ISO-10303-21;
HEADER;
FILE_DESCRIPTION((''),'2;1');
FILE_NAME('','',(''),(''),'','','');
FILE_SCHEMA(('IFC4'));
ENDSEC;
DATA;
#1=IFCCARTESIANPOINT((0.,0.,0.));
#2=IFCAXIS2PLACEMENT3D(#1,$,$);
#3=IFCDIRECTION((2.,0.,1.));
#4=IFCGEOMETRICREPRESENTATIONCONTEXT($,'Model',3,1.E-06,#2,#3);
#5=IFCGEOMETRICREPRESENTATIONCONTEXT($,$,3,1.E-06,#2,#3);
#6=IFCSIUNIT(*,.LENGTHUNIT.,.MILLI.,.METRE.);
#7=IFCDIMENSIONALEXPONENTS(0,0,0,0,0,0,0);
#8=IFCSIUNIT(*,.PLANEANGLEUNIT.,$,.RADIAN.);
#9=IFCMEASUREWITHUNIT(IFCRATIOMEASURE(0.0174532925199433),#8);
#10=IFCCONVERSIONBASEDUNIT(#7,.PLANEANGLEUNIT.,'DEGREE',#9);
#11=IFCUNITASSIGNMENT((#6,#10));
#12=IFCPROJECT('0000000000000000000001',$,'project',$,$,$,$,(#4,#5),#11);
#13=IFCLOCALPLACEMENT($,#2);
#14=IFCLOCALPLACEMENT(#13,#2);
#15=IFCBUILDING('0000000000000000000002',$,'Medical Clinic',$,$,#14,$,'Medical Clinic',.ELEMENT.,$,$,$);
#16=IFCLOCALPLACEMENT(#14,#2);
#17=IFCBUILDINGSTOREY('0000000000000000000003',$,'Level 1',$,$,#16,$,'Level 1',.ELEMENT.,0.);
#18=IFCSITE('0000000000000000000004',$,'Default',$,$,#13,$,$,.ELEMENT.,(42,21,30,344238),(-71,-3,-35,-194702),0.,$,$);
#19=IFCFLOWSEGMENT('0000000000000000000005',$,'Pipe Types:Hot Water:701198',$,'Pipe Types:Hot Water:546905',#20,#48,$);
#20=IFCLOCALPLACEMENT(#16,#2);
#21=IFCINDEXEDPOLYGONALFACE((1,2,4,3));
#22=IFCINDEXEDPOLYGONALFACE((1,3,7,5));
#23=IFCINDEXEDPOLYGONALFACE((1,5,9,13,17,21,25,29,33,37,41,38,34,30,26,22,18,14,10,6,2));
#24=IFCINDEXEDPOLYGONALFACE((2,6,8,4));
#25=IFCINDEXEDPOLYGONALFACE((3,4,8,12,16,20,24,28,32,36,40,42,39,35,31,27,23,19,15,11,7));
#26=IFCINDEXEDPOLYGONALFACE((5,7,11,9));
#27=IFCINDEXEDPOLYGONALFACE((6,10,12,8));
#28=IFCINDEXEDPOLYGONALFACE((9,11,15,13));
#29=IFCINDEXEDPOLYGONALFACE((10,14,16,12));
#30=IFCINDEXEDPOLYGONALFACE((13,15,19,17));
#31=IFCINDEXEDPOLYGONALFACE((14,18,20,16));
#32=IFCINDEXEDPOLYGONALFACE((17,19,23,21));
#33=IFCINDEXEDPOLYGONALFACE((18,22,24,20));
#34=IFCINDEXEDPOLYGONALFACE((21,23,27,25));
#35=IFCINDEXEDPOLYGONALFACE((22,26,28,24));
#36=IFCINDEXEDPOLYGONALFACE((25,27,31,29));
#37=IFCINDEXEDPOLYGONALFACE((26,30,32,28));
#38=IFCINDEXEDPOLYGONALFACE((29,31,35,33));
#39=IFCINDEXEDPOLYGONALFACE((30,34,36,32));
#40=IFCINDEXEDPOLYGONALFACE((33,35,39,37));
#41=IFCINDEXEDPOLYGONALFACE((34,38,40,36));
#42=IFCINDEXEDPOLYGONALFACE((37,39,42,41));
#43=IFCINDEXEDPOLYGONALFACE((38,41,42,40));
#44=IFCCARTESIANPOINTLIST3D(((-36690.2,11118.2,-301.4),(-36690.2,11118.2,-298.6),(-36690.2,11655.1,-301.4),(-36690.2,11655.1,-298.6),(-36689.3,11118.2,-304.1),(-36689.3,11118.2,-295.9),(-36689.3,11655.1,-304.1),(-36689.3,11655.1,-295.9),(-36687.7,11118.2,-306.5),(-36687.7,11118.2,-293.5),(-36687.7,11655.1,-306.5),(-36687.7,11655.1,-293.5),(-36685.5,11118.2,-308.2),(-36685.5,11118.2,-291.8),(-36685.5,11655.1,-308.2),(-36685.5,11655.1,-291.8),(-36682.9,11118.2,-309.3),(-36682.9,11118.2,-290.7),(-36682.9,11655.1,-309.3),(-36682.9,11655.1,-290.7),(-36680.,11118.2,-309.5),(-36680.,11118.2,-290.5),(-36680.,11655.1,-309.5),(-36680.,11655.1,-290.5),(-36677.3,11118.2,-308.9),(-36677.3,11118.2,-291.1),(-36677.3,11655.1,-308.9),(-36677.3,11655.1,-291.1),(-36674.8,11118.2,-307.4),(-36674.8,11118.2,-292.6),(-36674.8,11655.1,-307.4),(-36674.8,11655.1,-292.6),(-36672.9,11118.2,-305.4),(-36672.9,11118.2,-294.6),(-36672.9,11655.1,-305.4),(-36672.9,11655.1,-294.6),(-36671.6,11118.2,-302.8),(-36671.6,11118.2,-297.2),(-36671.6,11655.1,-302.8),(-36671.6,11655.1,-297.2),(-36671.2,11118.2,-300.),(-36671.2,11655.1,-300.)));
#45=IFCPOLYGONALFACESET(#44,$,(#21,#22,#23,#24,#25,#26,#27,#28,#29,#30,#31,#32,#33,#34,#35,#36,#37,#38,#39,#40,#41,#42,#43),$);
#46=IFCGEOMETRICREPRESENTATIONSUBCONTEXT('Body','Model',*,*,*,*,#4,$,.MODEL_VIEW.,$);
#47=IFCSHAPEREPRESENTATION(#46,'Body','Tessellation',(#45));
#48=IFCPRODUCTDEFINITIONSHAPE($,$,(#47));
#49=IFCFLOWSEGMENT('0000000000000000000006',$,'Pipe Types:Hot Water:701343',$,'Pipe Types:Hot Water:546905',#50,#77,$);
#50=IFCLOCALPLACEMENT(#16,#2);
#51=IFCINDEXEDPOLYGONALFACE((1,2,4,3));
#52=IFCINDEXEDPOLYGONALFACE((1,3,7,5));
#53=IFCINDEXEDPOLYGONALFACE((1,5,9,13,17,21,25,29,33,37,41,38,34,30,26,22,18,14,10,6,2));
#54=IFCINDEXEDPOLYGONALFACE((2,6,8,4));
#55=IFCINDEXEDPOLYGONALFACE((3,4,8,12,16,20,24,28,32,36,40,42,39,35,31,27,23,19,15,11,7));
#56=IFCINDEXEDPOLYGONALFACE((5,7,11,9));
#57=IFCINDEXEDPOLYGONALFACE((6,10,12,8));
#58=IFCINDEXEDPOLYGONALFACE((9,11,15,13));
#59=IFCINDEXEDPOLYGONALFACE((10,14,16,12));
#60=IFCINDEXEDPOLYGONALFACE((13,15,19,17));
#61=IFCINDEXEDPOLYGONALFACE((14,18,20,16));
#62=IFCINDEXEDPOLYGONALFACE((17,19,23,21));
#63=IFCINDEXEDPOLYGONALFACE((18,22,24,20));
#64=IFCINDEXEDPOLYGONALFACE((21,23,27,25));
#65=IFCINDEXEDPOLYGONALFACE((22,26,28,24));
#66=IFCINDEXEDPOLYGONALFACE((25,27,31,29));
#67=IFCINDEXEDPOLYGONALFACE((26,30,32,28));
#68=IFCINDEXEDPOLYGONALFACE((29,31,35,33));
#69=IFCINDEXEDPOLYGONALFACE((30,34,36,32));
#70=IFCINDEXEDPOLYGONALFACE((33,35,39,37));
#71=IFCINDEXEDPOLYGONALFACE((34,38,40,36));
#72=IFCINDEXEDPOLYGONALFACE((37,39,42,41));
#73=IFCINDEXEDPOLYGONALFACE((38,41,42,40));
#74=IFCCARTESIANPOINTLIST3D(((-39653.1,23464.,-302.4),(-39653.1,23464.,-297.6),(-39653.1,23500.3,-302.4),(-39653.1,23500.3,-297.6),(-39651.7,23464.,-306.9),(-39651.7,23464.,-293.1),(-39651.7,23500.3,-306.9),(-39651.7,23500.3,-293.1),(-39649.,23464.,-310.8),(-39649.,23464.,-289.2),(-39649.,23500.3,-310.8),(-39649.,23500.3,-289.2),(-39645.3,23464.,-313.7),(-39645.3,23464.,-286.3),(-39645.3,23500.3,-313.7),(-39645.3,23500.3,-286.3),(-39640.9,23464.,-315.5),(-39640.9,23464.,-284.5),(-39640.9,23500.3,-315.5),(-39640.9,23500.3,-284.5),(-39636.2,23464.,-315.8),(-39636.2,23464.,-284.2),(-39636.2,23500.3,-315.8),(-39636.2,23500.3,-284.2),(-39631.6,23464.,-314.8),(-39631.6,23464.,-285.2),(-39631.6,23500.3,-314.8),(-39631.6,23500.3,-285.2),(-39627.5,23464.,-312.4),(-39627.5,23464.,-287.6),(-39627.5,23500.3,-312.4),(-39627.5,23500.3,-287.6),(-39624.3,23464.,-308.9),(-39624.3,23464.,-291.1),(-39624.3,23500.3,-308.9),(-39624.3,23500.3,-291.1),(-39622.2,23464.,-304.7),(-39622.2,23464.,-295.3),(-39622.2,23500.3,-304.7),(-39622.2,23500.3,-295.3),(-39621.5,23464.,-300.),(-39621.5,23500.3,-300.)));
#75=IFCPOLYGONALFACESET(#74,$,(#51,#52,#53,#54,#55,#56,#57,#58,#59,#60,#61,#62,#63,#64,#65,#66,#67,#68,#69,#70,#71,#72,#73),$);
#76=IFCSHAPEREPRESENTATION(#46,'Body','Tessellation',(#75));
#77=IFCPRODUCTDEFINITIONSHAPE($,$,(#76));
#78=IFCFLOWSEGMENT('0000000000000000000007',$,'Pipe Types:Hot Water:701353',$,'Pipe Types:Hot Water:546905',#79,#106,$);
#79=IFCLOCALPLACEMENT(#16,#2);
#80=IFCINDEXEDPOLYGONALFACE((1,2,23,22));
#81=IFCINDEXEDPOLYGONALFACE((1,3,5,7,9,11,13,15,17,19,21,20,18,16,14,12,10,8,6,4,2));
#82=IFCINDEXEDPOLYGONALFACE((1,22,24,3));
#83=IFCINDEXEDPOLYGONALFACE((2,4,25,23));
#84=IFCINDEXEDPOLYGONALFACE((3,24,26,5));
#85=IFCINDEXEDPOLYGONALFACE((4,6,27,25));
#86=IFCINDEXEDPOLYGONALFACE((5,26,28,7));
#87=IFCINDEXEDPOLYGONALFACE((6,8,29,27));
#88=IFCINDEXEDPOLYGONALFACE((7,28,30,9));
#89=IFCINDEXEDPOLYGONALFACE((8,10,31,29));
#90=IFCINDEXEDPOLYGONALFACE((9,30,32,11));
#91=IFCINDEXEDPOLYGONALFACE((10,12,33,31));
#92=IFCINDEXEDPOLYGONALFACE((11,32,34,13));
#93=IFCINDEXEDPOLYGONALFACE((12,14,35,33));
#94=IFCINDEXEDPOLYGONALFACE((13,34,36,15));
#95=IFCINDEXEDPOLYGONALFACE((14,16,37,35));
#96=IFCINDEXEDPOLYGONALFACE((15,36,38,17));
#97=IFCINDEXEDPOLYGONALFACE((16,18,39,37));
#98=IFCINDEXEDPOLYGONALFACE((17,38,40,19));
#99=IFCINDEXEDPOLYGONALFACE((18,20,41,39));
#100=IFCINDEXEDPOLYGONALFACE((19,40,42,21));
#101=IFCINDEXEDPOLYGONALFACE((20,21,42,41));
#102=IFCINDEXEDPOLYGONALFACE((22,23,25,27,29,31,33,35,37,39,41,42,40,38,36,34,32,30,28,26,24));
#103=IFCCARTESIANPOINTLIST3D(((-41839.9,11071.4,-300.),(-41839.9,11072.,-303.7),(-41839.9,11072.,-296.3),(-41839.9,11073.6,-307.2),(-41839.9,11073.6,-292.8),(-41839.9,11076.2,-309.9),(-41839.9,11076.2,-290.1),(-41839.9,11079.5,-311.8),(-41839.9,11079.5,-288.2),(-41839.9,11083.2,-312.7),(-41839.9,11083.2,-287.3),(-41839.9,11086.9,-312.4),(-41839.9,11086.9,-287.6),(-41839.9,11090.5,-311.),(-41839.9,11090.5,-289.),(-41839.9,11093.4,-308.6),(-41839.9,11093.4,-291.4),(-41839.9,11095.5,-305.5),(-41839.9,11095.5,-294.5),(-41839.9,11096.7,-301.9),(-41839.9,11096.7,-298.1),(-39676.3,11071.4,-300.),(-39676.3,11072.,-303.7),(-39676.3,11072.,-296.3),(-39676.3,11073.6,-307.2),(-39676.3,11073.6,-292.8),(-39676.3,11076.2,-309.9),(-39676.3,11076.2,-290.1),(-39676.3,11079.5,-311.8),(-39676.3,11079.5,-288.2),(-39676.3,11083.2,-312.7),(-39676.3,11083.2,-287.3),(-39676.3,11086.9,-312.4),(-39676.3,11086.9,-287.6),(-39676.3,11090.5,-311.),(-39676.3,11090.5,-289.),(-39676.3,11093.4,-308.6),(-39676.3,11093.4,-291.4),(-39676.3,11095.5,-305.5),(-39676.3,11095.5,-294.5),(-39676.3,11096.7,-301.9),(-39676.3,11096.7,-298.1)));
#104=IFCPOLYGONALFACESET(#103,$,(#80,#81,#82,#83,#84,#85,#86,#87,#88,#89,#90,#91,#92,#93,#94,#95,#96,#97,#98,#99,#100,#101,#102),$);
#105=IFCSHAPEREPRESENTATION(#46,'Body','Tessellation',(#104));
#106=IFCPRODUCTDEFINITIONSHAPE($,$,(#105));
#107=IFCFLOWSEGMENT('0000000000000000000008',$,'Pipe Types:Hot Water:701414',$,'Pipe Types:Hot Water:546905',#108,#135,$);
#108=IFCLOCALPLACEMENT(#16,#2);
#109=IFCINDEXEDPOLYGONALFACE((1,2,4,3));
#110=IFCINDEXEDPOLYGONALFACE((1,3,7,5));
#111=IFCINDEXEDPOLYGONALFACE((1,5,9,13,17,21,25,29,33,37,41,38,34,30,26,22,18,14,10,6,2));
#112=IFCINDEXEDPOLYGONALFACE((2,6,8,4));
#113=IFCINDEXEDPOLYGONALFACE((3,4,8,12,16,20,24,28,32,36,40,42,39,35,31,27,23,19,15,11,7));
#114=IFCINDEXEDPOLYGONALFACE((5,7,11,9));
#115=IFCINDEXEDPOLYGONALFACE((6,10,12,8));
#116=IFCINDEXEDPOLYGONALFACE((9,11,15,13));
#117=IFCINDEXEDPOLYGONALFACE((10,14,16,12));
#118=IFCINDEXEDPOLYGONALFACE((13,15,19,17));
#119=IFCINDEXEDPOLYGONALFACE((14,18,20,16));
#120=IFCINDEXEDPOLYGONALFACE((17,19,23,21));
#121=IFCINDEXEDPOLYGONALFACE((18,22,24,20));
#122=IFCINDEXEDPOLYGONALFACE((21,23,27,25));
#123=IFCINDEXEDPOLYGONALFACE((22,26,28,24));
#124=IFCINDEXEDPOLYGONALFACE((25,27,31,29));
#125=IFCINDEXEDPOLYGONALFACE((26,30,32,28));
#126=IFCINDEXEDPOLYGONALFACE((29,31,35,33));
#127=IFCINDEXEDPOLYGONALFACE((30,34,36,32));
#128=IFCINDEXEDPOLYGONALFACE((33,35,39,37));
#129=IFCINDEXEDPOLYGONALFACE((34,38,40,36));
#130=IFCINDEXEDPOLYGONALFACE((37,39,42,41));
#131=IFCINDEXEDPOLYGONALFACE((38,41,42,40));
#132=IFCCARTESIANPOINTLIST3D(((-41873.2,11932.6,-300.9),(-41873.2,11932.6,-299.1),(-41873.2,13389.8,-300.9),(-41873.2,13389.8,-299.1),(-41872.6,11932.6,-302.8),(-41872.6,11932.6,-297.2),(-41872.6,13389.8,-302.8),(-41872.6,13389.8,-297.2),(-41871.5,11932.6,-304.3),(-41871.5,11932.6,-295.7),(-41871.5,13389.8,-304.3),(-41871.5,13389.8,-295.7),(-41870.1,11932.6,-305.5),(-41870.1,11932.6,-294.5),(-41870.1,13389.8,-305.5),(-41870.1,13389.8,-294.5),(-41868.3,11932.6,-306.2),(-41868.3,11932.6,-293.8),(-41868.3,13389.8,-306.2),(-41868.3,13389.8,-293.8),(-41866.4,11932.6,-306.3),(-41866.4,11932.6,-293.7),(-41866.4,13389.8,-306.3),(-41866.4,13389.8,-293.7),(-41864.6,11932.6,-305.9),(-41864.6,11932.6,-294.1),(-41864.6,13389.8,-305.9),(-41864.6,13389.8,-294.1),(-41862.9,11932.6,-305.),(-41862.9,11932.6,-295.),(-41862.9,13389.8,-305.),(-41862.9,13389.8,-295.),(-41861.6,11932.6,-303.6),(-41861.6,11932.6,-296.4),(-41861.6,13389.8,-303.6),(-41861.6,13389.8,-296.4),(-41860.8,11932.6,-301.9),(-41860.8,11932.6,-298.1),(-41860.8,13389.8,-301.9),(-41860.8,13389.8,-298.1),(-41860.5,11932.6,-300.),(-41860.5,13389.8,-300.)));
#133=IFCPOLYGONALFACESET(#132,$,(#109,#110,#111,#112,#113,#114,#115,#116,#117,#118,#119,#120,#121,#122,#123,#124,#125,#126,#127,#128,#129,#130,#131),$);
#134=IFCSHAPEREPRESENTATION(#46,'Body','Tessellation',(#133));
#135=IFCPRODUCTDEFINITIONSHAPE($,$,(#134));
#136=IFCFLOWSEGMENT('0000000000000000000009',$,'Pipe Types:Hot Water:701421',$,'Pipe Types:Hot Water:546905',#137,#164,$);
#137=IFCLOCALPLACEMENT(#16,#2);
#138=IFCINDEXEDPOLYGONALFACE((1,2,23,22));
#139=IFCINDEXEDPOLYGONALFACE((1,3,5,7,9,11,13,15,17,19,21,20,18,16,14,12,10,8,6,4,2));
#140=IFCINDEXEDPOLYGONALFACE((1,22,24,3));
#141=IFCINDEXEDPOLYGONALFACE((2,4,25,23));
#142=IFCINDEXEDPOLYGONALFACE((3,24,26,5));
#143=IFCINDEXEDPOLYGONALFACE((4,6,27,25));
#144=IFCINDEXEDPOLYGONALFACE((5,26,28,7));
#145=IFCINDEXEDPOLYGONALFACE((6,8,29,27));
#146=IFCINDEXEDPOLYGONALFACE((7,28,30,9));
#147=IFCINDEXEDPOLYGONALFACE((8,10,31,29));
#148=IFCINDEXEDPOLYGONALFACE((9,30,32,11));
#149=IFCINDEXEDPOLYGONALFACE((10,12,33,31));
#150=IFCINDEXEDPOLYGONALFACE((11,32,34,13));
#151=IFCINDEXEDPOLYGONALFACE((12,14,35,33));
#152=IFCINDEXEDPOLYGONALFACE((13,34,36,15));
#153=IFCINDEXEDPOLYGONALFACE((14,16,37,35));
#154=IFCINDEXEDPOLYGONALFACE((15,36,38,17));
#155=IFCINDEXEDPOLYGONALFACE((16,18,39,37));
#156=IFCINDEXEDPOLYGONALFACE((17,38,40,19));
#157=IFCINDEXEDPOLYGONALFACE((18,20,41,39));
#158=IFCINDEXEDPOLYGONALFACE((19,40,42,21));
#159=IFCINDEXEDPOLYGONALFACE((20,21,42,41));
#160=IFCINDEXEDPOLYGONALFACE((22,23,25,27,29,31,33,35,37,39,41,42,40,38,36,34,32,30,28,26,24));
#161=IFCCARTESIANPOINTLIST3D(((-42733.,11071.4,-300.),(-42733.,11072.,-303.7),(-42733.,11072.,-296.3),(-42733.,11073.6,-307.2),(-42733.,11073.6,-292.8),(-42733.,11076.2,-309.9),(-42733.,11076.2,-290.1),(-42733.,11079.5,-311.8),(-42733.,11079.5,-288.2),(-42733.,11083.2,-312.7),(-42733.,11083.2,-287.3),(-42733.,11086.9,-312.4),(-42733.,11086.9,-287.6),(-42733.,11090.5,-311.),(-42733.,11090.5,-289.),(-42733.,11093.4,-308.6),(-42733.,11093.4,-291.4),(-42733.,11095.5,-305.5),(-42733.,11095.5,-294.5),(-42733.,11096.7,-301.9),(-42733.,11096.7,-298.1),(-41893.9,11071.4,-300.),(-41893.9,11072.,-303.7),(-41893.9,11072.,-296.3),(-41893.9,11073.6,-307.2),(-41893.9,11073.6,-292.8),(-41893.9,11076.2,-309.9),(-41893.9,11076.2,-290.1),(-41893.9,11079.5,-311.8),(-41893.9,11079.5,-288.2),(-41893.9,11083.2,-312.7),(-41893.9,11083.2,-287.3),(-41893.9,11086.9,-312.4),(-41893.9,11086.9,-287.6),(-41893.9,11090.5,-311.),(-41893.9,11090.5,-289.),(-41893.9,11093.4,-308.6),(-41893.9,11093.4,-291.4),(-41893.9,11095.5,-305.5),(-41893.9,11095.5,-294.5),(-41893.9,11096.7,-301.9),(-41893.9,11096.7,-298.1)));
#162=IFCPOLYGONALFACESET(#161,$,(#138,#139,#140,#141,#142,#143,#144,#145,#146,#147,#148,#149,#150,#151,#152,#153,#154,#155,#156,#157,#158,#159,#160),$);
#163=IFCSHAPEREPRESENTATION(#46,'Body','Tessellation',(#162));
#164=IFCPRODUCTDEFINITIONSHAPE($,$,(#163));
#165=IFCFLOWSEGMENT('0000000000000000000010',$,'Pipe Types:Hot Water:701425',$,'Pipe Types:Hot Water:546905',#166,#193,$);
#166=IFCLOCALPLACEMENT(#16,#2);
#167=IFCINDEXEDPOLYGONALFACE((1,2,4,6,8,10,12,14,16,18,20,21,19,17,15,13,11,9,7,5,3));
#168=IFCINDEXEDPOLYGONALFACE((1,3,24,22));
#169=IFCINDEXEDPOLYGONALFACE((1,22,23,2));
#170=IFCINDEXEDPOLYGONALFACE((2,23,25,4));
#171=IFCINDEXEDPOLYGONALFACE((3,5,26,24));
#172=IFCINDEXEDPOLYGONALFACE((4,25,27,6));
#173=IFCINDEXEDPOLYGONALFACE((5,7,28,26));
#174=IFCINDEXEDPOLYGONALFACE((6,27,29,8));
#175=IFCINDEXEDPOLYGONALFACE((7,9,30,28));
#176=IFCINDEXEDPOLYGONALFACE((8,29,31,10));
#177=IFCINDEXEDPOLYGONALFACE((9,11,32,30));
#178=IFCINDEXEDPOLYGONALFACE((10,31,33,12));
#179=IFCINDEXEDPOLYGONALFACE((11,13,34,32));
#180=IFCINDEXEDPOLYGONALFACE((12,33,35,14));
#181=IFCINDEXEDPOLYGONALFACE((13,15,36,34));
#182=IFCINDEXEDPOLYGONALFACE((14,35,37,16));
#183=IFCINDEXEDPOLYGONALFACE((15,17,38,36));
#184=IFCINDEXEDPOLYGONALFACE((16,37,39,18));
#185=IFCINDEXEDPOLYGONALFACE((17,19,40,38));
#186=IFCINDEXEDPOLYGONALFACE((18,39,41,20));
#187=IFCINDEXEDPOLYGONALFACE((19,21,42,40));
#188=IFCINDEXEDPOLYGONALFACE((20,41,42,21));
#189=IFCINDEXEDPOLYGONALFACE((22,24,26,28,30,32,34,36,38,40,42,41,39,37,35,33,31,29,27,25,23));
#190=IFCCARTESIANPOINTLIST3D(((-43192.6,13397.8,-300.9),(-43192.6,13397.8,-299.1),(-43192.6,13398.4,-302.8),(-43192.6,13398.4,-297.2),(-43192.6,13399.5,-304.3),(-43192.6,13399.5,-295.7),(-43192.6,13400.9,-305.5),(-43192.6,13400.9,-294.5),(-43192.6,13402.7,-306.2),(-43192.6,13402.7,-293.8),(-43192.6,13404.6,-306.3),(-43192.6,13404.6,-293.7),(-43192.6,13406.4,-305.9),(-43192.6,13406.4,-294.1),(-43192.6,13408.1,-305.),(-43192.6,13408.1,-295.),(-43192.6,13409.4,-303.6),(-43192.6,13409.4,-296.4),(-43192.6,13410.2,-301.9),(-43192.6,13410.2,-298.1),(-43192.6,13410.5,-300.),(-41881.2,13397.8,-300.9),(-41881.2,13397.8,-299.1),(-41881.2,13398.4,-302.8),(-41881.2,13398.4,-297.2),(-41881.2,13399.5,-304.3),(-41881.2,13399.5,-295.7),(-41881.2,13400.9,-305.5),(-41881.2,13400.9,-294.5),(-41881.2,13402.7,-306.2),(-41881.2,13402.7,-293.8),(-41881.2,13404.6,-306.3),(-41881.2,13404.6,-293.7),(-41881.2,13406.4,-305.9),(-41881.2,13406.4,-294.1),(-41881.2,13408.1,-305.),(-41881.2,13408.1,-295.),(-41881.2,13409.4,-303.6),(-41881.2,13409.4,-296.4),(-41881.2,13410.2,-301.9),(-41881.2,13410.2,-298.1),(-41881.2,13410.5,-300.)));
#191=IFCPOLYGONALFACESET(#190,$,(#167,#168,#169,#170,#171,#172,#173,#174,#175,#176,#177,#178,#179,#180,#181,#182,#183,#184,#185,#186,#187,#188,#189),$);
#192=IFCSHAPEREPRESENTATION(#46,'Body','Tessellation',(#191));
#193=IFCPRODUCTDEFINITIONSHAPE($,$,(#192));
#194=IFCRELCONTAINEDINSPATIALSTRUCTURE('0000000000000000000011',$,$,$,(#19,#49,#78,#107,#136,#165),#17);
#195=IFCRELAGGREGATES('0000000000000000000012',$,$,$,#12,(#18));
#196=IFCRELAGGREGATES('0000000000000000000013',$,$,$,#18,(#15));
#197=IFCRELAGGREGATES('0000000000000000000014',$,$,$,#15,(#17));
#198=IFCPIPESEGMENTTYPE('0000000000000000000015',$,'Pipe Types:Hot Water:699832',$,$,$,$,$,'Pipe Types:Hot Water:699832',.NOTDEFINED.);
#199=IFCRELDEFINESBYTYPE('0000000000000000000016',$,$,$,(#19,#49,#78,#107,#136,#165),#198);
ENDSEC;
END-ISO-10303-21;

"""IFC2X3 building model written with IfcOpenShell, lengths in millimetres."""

from ifc_helpers import new_model, entity, si_unit, converted_unit, direction, frame, frame_2d, origin, origin_2d_with_axis, place, context, subcontext, project, spatial, circle, extrude, type_object, element, save


model = new_model("IFC2X3")

# Units and contexts
model_context = context("Model", 3, precision=1e-06, world=origin(), true_north=direction((2.0, 0.0, 1.0)))
context_of_model = context(None, 3, precision=1e-06, world=origin(), true_north=direction((2.0, 0.0, 1.0)))
body_context = subcontext(model_context, "Body", "Model", "MODEL_VIEW")
ifc_project = project(units=[si_unit("LENGTHUNIT", "METRE", prefix="MILLI"), converted_unit("PLANEANGLEUNIT", "DEGREE", entity("IfcRatioMeasure", 0.0174532925199433), si_unit("PLANEANGLEUNIT", "RADIAN"), dimensions=[0, 0, 0, 0, 0, 0, 0])], contexts=[model_context, context_of_model])

# Site, building, storey
site_placement = place(None, origin())
site = spatial("IfcSite", under=ifc_project, at=site_placement, Name="Default", CompositionType="ELEMENT", RefLatitude=(42, 21, 30, 344238), RefLongitude=(-71, -3, -35, -194702), RefElevation=0.0)
building_placement = place(site_placement, origin())
building = spatial("IfcBuilding", under=site, at=building_placement, Name="Medical Clinic", LongName="Medical Clinic", CompositionType="ELEMENT")
storey_placement = place(building_placement, origin())
storey = spatial("IfcBuildingStorey", under=building, at=storey_placement, Name="Level 1", LongName="Level 1", CompositionType="ELEMENT", Elevation=0.0)

# Flow segments
pipe_segment_type_1 = type_object("IfcPipeSegmentType", Name="Pipe Types:Hot Water:699832", ElementType="Pipe Types:Hot Water:699832", PredefinedType="NOTDEFINED")
flow_segment_1_placement = place(storey_placement, origin())
element("IfcFlowSegment", 1, at=flow_segment_1_placement, inside=storey, type_object=pipe_segment_type_1, Name="Pipe Types:Hot Water:701198", ObjectType="Pipe Types:Hot Water:546905", context=body_context, shape_type="SweptSolid", body=[
    extrude(circle(Radius=9.5, at=frame_2d((0.0, 0.0), x_axis=(1.0, 0.0))), frame((-36680.7, 11118.2, -300.0), z_axis=(0.0, 1.0, 0.0), x_axis=(1.0, 0.0, 0.0)), (0.0, 0.0, 1.0), 536.9),
])
flow_segment_2_placement = place(storey_placement, origin())
element("IfcFlowSegment", 2, at=flow_segment_2_placement, inside=storey, type_object=pipe_segment_type_1, Name="Pipe Types:Hot Water:701343", ObjectType="Pipe Types:Hot Water:546905", context=body_context, shape_type="SweptSolid", body=[
    extrude(circle(Radius=15.9, at=origin_2d_with_axis()), frame((-39637.4, 23464.0, -300.0), z_axis=(0.0, 1.0, 0.0), x_axis=(1.0, 0.0, 0.0)), (0.0, 0.0, 1.0), 36.3),
])
flow_segment_3_placement = place(storey_placement, origin())
element("IfcFlowSegment", 3, at=flow_segment_3_placement, inside=storey, type_object=pipe_segment_type_1, Name="Pipe Types:Hot Water:701353", ObjectType="Pipe Types:Hot Water:546905", context=body_context, shape_type="SweptSolid", body=[
    extrude(circle(Radius=12.7, at=frame_2d((0.0, 0.0), x_axis=(1.0, 0.0))), frame((-41839.9, 11084.1, -300.0), z_axis=(1.0, 0.0, 0.0), x_axis=(0.0, -1.0, 0.0)), (0.0, 0.0, 1.0), 2163.6),
])
flow_segment_4_placement = place(storey_placement, origin())
element("IfcFlowSegment", 4, at=flow_segment_4_placement, inside=storey, type_object=pipe_segment_type_1, Name="Pipe Types:Hot Water:701414", ObjectType="Pipe Types:Hot Water:546905", context=body_context, shape_type="SweptSolid", body=[
    extrude(circle(Radius=6.3, at=origin_2d_with_axis()), frame((-41866.9, 11932.6, -300.0), z_axis=(0.0, 1.0, 0.0), x_axis=(1.0, 0.0, 0.0)), (0.0, 0.0, 1.0), 1457.2),
])
flow_segment_5_placement = place(storey_placement, origin())
element("IfcFlowSegment", 5, at=flow_segment_5_placement, inside=storey, type_object=pipe_segment_type_1, Name="Pipe Types:Hot Water:701421", ObjectType="Pipe Types:Hot Water:546905", context=body_context, shape_type="SweptSolid", body=[
    extrude(circle(Radius=12.7, at=frame_2d((0.0, 0.0), x_axis=(1.0, 0.0))), frame((-42733.0, 11084.1, -300.0), z_axis=(1.0, 0.0, 0.0), x_axis=(0.0, -1.0, 0.0)), (0.0, 0.0, 1.0), 839.1),
])
flow_segment_6_placement = place(storey_placement, origin())
element("IfcFlowSegment", 6, at=flow_segment_6_placement, inside=storey, type_object=pipe_segment_type_1, Name="Pipe Types:Hot Water:701425", ObjectType="Pipe Types:Hot Water:546905", context=body_context, shape_type="SweptSolid", body=[
    extrude(circle(Radius=6.3, at=frame_2d((0.0, 0.0), x_axis=(1.0, 0.0))), frame((-43192.6, 13404.1, -300.0), z_axis=(1.0, 0.0, 0.0), x_axis=(0.0, 1.0, 0.0)), (0.0, 0.0, 1.0), 1311.4),
])

save(model, "model.ifc")
